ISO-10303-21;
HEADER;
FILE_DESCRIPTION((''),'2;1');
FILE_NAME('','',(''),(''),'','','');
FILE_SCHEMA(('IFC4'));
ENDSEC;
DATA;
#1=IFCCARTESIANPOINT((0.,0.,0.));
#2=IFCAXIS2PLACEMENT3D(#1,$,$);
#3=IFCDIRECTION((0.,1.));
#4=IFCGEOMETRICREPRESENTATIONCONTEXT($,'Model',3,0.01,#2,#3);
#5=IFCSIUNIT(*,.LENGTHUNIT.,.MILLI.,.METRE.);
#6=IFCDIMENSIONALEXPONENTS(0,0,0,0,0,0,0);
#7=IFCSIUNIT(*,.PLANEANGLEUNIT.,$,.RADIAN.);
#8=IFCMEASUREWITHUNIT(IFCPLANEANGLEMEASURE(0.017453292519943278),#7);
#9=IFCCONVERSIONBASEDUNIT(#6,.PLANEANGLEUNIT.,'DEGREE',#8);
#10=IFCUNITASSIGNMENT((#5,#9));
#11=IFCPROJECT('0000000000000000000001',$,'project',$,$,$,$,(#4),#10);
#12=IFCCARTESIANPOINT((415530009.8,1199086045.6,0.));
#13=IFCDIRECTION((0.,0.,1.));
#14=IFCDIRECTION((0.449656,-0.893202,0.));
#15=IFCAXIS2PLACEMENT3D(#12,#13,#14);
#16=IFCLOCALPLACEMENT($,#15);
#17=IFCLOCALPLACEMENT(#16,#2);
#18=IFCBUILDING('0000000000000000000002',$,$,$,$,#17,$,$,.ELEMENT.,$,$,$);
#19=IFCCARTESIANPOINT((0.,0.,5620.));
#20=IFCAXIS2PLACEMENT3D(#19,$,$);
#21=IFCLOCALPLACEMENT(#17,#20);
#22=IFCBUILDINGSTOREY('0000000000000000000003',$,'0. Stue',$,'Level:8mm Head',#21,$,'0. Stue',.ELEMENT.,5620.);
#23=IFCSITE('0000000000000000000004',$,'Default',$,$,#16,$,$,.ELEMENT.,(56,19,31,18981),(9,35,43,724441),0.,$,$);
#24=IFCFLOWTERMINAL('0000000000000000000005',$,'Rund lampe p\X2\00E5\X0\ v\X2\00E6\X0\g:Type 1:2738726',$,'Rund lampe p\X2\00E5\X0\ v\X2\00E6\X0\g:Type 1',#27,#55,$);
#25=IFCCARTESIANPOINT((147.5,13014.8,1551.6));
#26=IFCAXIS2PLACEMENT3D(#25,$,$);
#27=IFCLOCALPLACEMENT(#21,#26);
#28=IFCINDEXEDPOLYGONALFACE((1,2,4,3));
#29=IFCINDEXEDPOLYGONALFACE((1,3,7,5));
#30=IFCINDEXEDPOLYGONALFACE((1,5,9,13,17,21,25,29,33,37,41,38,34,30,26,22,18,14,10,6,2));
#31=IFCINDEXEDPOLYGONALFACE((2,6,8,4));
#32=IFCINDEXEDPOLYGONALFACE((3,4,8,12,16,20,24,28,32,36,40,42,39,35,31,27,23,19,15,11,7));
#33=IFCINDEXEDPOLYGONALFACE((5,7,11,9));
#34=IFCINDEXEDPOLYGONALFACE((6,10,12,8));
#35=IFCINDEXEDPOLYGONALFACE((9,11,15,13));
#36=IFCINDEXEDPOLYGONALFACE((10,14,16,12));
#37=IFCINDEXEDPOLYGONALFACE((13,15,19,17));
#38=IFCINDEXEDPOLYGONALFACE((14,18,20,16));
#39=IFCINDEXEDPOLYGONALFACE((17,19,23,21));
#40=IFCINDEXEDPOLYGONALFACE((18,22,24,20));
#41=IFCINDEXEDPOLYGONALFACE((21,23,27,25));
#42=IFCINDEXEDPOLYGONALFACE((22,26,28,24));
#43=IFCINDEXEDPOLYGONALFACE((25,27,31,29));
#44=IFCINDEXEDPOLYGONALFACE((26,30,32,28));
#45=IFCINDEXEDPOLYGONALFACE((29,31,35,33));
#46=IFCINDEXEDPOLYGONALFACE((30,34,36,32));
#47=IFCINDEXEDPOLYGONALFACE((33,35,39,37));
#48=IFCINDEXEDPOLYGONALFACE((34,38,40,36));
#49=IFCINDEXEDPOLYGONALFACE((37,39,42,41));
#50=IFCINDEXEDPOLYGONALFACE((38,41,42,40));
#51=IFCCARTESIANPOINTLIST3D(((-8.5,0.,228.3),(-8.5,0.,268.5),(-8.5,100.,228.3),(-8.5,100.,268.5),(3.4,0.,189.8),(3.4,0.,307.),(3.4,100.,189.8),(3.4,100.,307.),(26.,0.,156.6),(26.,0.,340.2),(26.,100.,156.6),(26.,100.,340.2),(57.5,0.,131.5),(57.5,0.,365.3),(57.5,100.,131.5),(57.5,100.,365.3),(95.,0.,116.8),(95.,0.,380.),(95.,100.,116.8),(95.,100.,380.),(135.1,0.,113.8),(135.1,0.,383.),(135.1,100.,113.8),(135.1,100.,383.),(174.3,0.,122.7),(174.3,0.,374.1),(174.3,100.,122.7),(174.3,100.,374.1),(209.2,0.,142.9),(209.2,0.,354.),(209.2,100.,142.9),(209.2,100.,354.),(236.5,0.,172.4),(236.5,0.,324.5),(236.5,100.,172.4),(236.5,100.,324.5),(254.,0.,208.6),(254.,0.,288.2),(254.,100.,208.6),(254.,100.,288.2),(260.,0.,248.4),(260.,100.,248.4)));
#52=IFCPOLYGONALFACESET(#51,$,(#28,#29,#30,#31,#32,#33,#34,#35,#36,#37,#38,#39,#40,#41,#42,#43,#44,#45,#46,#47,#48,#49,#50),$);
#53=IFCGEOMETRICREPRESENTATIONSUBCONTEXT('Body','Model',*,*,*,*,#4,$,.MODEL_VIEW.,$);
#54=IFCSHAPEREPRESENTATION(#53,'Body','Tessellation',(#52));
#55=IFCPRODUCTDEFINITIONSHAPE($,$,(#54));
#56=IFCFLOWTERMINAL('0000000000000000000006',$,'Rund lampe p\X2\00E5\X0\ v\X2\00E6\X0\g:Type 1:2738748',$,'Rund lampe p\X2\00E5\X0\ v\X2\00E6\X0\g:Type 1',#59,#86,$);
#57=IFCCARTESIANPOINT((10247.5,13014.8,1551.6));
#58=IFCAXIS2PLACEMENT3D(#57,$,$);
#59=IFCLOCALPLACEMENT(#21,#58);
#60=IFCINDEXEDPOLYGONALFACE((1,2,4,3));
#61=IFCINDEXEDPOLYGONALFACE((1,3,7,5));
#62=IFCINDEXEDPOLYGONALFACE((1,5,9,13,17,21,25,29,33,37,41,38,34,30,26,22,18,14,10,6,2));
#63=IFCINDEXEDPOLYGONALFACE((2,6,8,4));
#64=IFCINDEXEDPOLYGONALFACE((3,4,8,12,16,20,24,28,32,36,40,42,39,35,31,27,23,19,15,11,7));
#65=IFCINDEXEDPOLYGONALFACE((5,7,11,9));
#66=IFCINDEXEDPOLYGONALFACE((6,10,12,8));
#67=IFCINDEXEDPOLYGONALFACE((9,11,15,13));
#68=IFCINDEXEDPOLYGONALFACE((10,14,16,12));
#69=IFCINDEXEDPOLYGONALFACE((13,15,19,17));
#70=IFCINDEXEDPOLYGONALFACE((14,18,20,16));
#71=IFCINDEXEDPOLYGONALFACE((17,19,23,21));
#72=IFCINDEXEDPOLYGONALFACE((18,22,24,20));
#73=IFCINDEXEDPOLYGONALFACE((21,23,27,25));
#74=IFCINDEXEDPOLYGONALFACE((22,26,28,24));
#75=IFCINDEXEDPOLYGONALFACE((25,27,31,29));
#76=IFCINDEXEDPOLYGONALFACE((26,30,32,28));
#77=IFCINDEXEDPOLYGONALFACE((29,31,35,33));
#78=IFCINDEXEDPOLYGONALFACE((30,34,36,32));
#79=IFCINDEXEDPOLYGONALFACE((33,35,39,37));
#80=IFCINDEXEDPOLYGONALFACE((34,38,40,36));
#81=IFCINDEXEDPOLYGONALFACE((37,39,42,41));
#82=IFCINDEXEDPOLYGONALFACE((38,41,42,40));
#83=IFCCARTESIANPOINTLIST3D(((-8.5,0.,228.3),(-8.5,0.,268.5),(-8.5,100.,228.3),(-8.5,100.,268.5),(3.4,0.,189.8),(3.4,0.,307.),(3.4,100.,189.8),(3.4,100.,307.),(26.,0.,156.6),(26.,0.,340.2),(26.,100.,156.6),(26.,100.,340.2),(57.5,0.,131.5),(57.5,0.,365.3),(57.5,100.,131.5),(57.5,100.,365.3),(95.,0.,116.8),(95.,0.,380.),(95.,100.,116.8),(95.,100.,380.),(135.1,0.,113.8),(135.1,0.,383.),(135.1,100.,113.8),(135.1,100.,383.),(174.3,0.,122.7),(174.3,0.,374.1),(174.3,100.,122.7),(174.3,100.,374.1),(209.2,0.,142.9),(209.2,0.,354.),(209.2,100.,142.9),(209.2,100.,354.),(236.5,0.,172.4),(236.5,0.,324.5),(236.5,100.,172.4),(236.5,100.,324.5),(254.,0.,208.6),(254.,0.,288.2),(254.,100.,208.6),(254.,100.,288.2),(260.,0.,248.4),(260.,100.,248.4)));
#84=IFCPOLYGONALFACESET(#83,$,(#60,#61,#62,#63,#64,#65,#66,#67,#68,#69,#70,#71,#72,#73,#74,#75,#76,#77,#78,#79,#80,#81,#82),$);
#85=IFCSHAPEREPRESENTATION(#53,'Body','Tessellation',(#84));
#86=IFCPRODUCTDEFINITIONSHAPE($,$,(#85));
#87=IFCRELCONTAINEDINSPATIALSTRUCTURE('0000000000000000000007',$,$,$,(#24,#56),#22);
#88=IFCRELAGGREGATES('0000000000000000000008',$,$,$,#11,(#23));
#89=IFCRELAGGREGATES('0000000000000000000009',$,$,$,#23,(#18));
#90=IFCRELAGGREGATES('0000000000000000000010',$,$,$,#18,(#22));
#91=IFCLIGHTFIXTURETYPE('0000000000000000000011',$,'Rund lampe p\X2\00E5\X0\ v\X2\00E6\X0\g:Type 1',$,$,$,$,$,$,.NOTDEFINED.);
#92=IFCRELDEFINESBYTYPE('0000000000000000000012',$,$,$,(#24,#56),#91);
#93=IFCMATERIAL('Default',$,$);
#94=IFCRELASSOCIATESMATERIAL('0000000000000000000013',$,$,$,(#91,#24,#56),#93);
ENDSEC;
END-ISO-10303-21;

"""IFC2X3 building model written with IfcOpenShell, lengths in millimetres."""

from ifc_helpers import new_model, entity, si_unit, converted_unit, direction, frame, frame_2d, origin, place, context, subcontext, project, spatial, circle, extrude, source, transform, mapped, material, type_object, type_shapes, element, save


model = new_model("IFC2X3")

# Units and contexts
model_context = context("Model", 3, precision=0.01, world=origin(), true_north=direction((0.0, 1.0)))
body_context = subcontext(model_context, "Body", "Model", "MODEL_VIEW")
ifc_project = project(units=[si_unit("LENGTHUNIT", "METRE", prefix="MILLI"), converted_unit("PLANEANGLEUNIT", "DEGREE", entity("IfcPlaneAngleMeasure", 0.017453292519943278), si_unit("PLANEANGLEUNIT", "RADIAN"), dimensions=[0, 0, 0, 0, 0, 0, 0])], contexts=[model_context])

# Site, building, storey
site_placement = place(None, frame((415530009.8, 1199086045.6, 0.0), z_axis=(0.0, 0.0, 1.0), x_axis=(0.449656, -0.893202, 0.0)))
site = spatial("IfcSite", under=ifc_project, at=site_placement, Name="Default", CompositionType="ELEMENT", RefLatitude=(56, 19, 31, 18981), RefLongitude=(9, 35, 43, 724441), RefElevation=0.0)
building_placement = place(site_placement, origin())
building = spatial("IfcBuilding", under=site, at=building_placement, CompositionType="ELEMENT")
storey_placement = place(building_placement, frame((0.0, 0.0, 5620.0)))
storey = spatial("IfcBuildingStorey", under=building, at=storey_placement, Name="0. Stue", ObjectType="Level:8mm Head", LongName="0. Stue", CompositionType="ELEMENT", Elevation=5620.0)

# Flow terminals
ifc_material_1 = material(Name="Default")
light_fixture_type_1 = type_object("IfcLightFixtureType", Name="Rund lampe på væg:Type 1", PredefinedType="NOTDEFINED", material=ifc_material_1)
shared_shape_1 = source(origin(), body_context, "Body", "SweptSolid", [
    extrude(circle(Radius=135.0, at=frame_2d((0.0, 0.0), x_axis=(1.0, 0.0))), frame((125.0, 0.0, 248.4), z_axis=(0.0, 1.0, 0.0), x_axis=(1.0, 0.0, 0.0)), (0.0, 0.0, 1.0), 100.0),
])
type_shapes(light_fixture_type_1, [shared_shape_1])
for number, where, name in (
    (1, (147.5, 13014.8, 1551.6), "Rund lampe på væg:Type 1:2738726"),
    (2, (10247.5, 13014.8, 1551.6), "Rund lampe på væg:Type 1:2738748"),
):
    element("IfcFlowTerminal", number, at=place(storey_placement, frame(where)), inside=storey, type_object=light_fixture_type_1, material=ifc_material_1, Name=name, ObjectType="Rund lampe på væg:Type 1", context=body_context, shape_type="MappedRepresentation", body=[
        mapped(shared_shape_1, transform((0.0, 0.0, 0.0), scale=1.0)),
    ])

save(model, "model.ifc")
